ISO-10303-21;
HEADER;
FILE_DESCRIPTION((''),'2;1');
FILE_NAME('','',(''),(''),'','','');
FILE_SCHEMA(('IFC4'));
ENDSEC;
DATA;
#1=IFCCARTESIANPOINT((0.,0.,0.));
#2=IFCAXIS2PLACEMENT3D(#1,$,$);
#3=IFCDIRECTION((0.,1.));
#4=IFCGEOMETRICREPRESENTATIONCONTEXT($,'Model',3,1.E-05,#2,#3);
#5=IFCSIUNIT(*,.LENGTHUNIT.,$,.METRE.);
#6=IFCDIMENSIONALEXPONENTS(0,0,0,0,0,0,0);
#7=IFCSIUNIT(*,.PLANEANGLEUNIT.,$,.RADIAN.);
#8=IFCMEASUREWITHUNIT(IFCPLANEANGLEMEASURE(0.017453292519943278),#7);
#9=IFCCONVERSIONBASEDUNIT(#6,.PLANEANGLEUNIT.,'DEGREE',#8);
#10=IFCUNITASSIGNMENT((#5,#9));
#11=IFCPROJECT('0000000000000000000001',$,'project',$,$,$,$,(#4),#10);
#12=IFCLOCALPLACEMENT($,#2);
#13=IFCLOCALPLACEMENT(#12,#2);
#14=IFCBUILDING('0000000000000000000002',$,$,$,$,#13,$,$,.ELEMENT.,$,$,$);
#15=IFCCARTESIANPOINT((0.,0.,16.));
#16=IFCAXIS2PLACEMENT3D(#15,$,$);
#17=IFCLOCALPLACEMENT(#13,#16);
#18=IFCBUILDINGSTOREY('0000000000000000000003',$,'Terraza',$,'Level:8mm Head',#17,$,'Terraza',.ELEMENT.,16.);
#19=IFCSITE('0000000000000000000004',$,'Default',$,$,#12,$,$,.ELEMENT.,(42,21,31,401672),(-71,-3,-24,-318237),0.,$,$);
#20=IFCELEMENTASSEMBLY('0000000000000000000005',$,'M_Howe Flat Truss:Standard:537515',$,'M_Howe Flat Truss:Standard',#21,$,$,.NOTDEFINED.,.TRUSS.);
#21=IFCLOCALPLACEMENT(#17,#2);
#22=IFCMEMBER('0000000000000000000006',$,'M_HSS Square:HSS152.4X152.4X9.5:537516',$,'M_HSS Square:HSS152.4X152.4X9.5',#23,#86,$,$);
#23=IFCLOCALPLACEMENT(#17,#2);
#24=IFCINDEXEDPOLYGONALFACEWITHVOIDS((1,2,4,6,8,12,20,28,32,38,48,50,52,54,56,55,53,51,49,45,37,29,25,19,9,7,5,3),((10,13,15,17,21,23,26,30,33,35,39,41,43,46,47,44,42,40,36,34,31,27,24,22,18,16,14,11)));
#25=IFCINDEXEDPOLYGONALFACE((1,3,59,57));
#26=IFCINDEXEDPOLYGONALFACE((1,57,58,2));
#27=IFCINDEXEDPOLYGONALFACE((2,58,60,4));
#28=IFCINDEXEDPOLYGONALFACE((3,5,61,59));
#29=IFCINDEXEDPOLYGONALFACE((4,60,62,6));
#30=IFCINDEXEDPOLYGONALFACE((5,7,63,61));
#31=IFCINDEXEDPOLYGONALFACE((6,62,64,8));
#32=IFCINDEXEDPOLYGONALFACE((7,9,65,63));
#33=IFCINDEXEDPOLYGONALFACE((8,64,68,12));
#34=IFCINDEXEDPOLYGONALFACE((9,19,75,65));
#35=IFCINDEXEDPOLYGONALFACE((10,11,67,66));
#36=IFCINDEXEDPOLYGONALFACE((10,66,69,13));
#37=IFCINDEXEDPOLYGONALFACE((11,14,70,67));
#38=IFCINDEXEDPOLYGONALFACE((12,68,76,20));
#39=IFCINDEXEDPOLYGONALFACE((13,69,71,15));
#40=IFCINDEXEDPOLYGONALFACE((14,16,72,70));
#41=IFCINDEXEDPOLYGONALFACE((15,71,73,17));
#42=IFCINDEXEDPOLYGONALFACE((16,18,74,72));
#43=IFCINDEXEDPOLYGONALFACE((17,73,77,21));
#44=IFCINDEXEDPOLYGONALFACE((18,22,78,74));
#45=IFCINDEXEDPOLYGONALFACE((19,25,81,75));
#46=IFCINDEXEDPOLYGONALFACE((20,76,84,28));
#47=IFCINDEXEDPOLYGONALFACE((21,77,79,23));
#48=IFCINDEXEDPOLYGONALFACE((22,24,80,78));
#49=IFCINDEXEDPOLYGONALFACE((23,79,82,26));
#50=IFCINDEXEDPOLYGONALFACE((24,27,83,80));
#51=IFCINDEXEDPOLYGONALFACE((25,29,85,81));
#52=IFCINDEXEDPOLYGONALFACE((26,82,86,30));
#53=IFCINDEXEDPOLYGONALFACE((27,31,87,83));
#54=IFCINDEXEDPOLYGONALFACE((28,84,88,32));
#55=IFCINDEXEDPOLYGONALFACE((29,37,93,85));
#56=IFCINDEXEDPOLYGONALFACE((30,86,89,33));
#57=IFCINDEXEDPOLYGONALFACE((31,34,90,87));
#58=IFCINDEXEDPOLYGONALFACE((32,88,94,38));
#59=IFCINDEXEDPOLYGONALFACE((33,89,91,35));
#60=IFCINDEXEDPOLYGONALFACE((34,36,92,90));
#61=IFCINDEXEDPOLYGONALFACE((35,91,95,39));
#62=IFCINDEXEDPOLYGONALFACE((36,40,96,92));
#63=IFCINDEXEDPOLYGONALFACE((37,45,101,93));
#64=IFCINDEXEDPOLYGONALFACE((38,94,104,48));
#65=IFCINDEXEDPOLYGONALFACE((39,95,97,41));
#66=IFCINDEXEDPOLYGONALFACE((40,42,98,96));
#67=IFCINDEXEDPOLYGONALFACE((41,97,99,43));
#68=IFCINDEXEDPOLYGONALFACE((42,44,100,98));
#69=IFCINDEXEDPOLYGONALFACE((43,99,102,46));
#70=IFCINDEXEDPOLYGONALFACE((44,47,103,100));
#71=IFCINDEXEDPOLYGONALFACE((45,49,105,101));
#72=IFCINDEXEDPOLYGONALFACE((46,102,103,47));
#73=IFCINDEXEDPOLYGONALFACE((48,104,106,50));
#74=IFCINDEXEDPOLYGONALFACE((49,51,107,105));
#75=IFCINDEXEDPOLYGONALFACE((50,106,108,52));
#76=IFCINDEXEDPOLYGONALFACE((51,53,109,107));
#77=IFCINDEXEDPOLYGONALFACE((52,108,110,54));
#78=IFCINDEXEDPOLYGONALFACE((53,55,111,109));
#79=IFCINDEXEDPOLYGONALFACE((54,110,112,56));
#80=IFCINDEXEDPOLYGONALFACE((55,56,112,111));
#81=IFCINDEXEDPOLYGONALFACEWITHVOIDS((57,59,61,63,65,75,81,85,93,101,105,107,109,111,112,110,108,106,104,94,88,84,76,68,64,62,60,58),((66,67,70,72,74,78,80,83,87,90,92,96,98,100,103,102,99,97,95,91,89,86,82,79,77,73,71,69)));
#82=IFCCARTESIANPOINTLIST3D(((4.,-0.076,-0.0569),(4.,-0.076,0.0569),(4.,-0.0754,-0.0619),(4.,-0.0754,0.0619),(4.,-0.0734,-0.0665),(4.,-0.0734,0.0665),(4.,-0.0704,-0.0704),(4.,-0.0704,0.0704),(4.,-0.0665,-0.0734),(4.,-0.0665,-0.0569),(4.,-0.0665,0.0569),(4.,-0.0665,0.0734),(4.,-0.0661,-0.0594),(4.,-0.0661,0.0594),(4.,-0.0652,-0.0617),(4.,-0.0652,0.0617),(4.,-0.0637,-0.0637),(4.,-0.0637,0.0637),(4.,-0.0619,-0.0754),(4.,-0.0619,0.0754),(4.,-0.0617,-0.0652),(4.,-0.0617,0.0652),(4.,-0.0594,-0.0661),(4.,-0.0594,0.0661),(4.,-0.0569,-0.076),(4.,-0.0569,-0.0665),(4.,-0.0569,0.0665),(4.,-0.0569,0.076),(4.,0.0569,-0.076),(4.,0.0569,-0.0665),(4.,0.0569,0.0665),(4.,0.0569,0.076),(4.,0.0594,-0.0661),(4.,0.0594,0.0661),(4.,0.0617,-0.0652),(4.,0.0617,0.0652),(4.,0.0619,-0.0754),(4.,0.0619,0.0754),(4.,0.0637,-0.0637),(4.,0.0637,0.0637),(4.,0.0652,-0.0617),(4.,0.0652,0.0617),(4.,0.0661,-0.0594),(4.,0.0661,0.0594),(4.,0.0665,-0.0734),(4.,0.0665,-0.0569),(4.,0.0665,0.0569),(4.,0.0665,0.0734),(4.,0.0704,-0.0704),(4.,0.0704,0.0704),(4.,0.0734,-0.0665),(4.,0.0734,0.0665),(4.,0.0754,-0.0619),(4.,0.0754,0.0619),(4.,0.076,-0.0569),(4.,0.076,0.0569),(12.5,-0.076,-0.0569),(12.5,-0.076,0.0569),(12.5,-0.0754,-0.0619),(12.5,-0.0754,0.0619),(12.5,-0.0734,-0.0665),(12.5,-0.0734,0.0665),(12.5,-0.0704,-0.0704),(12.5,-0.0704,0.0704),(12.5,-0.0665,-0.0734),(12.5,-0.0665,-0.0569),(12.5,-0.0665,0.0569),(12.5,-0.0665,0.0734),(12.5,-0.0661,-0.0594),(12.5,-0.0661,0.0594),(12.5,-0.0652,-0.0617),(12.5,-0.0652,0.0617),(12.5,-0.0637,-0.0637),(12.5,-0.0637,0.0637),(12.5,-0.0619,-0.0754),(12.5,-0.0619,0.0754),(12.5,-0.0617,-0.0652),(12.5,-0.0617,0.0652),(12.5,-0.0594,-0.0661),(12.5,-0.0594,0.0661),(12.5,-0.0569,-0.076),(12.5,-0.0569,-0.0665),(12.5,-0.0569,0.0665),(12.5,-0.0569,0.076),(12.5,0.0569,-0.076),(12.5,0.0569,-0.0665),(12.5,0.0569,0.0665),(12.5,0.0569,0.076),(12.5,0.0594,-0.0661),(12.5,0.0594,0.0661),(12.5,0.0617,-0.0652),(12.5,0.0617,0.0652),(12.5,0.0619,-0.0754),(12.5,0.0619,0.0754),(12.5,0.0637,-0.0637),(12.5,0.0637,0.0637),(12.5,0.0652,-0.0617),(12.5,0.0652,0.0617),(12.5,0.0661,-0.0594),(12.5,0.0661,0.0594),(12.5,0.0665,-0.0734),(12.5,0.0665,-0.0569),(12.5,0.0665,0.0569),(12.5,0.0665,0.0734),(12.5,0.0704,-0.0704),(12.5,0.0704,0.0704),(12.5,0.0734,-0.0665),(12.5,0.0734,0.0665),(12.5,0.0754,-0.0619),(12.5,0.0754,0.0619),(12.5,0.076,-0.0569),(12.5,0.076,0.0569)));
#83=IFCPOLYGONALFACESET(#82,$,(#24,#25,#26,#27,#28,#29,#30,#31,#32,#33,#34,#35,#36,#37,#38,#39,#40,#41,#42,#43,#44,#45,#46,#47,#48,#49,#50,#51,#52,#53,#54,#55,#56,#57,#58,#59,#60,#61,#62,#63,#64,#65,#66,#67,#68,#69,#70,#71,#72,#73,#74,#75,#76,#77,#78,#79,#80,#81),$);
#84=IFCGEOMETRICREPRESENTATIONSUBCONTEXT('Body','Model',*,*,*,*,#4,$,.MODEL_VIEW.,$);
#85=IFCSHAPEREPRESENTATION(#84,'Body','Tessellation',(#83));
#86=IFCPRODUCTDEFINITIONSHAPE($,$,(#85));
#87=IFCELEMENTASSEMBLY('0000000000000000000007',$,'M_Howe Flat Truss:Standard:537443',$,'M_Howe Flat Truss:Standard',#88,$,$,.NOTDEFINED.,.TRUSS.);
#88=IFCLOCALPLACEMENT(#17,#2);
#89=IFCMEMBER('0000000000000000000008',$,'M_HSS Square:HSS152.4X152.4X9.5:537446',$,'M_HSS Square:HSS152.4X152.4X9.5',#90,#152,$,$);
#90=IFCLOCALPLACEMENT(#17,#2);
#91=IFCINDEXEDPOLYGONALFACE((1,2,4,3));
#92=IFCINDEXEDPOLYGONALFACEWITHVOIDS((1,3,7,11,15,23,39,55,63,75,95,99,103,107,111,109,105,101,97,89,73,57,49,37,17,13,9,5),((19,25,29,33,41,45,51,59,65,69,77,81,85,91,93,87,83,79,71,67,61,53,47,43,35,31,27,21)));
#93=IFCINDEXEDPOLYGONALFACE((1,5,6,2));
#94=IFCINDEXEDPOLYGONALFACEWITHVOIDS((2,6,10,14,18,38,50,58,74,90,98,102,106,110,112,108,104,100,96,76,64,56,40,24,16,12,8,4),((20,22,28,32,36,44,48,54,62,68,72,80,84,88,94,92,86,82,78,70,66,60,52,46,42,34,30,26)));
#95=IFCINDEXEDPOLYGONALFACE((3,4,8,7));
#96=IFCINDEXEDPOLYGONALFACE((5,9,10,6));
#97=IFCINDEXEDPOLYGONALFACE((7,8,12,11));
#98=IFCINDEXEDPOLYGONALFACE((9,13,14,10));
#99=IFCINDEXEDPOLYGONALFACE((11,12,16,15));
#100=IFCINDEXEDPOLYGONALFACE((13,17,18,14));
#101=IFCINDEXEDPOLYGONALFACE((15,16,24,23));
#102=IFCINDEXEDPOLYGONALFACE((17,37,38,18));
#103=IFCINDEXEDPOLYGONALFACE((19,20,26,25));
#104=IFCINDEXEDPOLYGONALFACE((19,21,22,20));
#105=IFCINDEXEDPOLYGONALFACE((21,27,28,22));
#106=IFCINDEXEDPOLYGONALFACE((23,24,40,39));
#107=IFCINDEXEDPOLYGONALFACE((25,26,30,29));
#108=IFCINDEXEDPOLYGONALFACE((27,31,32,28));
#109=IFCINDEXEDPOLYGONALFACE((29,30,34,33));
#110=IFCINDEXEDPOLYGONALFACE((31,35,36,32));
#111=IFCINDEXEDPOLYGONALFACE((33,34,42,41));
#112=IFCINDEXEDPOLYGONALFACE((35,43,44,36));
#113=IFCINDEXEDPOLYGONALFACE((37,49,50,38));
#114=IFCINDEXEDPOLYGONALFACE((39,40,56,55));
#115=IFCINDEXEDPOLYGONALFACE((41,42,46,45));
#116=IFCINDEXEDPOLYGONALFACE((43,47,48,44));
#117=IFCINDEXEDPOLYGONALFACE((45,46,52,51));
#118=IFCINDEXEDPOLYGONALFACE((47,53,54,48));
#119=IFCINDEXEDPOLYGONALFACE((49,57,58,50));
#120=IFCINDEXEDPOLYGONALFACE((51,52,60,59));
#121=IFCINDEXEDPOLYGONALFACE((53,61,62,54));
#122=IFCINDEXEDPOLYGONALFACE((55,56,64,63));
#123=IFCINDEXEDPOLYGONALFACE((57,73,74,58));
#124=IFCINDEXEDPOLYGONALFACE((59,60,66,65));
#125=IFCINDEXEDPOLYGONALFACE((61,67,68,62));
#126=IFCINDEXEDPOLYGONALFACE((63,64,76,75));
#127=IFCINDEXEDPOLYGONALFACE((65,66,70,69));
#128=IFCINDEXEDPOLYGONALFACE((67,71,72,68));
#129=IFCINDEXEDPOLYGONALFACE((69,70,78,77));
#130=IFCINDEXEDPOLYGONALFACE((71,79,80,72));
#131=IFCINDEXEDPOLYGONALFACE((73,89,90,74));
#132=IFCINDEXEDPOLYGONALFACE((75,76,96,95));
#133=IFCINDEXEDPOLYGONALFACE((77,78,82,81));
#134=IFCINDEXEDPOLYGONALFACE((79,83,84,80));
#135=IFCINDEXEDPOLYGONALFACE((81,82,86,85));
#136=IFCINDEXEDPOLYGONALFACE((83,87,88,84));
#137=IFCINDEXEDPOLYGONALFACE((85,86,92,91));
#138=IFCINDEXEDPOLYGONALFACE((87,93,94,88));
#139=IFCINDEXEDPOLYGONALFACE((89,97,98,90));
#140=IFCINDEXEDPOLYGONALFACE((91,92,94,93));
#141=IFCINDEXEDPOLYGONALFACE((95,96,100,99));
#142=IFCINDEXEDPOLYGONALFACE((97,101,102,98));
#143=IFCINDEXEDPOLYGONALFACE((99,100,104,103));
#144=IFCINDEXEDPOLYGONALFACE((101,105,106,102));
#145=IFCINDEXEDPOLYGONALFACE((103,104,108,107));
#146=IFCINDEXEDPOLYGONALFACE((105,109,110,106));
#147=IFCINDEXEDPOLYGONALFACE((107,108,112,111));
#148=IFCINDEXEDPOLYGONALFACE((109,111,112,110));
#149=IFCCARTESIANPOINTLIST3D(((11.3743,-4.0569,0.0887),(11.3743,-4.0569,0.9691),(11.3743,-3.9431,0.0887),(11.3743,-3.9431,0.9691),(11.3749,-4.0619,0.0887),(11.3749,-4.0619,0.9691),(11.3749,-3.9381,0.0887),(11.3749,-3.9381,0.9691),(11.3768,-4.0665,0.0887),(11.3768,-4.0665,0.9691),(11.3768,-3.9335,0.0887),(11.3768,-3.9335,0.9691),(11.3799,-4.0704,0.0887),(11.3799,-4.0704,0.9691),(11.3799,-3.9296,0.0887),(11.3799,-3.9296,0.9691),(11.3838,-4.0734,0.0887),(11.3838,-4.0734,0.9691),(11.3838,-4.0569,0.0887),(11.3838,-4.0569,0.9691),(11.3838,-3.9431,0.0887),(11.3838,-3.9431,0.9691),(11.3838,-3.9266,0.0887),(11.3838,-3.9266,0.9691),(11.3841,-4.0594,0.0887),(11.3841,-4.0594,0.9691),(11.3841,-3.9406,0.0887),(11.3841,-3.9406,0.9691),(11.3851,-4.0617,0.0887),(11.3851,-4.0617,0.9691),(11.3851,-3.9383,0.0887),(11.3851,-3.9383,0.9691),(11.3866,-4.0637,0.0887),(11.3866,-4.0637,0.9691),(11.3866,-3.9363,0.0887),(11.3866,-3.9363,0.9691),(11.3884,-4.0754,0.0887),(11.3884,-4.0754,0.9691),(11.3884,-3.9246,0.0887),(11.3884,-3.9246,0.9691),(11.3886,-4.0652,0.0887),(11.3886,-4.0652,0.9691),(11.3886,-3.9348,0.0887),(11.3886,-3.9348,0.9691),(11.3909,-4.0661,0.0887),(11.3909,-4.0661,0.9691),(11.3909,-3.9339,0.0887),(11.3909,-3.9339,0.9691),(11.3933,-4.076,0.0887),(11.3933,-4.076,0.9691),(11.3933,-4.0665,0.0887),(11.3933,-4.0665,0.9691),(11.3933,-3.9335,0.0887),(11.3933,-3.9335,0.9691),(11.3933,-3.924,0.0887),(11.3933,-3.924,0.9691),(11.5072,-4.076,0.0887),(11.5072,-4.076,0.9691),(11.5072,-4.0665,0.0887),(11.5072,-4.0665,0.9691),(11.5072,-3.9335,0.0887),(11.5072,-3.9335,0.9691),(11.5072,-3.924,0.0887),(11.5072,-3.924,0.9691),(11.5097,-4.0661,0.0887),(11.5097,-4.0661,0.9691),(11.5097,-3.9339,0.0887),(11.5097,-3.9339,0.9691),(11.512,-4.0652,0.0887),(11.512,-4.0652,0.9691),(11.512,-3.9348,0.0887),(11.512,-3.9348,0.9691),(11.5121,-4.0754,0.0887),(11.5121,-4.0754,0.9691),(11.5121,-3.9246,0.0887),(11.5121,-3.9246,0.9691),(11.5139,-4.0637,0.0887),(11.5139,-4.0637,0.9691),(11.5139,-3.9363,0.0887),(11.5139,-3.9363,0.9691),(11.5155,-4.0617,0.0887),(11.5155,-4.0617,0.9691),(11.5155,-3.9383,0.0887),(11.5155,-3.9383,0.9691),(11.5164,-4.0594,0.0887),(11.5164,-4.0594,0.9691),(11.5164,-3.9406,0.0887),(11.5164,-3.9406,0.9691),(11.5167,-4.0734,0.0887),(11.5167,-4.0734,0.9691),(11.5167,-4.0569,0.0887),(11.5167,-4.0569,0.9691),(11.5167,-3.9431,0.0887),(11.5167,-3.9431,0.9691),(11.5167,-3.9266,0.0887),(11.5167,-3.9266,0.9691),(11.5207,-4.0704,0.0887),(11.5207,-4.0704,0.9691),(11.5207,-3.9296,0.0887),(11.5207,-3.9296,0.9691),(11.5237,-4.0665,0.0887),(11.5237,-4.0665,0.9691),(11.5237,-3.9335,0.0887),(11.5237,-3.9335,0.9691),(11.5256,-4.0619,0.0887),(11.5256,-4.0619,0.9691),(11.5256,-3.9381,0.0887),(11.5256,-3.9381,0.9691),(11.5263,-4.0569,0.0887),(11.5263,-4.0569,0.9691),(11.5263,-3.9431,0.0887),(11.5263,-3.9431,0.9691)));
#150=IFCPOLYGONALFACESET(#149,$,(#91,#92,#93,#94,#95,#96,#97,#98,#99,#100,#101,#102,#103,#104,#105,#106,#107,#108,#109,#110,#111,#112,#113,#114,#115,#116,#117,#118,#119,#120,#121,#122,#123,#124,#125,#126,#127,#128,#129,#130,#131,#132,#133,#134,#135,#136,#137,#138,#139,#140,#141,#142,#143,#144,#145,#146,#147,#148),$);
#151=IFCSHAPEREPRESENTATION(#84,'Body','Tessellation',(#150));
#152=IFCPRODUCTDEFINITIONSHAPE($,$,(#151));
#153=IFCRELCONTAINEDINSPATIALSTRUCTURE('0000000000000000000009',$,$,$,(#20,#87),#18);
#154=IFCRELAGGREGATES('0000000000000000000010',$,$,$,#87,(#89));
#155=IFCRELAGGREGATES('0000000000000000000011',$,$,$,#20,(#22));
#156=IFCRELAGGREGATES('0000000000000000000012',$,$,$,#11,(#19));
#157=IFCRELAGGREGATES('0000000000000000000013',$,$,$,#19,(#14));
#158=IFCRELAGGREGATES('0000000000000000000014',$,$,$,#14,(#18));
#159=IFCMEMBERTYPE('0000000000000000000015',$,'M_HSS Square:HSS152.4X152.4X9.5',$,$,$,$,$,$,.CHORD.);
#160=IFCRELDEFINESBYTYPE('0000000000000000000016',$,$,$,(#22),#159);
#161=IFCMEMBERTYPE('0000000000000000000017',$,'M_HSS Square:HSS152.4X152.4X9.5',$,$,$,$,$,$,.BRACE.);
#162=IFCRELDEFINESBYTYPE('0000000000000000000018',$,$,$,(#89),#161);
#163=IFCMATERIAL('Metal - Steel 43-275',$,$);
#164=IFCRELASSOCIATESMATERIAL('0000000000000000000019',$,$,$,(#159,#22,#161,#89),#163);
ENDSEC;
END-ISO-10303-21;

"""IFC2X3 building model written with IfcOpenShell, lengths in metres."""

from ifc_helpers import new_model, entity, si_unit, converted_unit, direction, frame, frame_2d, origin, place, context, subcontext, project, spatial, polyline, circle_curve, parameter, trimmed, segment, composite_curve, outline, extrude, source, transform, mapped, material, type_object, type_shapes, element, aggregate, save


model = new_model("IFC2X3")

# Units and contexts
model_context = context("Model", 3, precision=1e-05, world=origin(), true_north=direction((0.0, 1.0)))
body_context = subcontext(model_context, "Body", "Model", "MODEL_VIEW")
ifc_project = project(units=[si_unit("LENGTHUNIT", "METRE"), converted_unit("PLANEANGLEUNIT", "DEGREE", entity("IfcPlaneAngleMeasure", 0.017453292519943278), si_unit("PLANEANGLEUNIT", "RADIAN"), dimensions=[0, 0, 0, 0, 0, 0, 0])], contexts=[model_context])

# Site, building, storey
site_placement = place(None, origin())
site = spatial("IfcSite", under=ifc_project, at=site_placement, Name="Default", CompositionType="ELEMENT", RefLatitude=(42, 21, 31, 401672), RefLongitude=(-71, -3, -24, -318237), RefElevation=0.0)
building_placement = place(site_placement, origin())
building = spatial("IfcBuilding", under=site, at=building_placement, CompositionType="ELEMENT")
storey_placement = place(building_placement, frame((0.0, 0.0, 16.0)))
storey = spatial("IfcBuildingStorey", under=building, at=storey_placement, Name="Terraza", ObjectType="Level:8mm Head", LongName="Terraza", CompositionType="ELEMENT", Elevation=16.0)

# Element assemblies, members
assembly_1_placement = place(storey_placement, origin())
assembly_1 = element("IfcElementAssembly", 1, at=assembly_1_placement, inside=storey, Name="M_Howe Flat Truss:Standard:537515", ObjectType="M_Howe Flat Truss:Standard", AssemblyPlace="NOTDEFINED", PredefinedType="TRUSS")
ifc_material_1 = material(Name="Metal - Steel 43-275")
member_type_1 = type_object("IfcMemberType", Name="M_HSS Square:HSS152.4X152.4X9.5", PredefinedType="CHORD", material=ifc_material_1)
shared_shape_1 = source(origin(), body_context, "Body", "SweptSolid", [
    extrude(outline(composite_curve([segment(polyline([(-0.0569, -0.076), (0.0569, -0.076)]), True, "CONTINUOUS"), segment(trimmed(circle_curve(frame_2d((0.0569, -0.0569), x_axis=(0.0, 1.0)), 0.0191), [parameter(180.0)], [parameter(270.0)], True, "PARAMETER"), True, "CONTINUOUS"), segment(polyline([(0.076, -0.0569), (0.076, 0.0569)]), True, "CONTINUOUS"), segment(trimmed(circle_curve(frame_2d((0.0569, 0.0569), x_axis=(0.0, 1.0)), 0.0191), [parameter(270.0)], [parameter(0.0)], True, "PARAMETER"), True, "CONTINUOUS"), segment(polyline([(0.0569, 0.076), (-0.0569, 0.076)]), True, "CONTINUOUS"), segment(trimmed(circle_curve(frame_2d((-0.0569, 0.0569), x_axis=(0.0, 1.0)), 0.0191), [parameter(0.0)], [parameter(90.0)], True, "PARAMETER"), True, "CONTINUOUS"), segment(polyline([(-0.076, 0.0569), (-0.076, -0.0569)]), True, "CONTINUOUS"), segment(trimmed(circle_curve(frame_2d((-0.0569, -0.0569), x_axis=(0.0, 1.0)), 0.0191), [parameter(90.0)], [parameter(180.0)], True, "PARAMETER"), True, "CONTINUOUS")], self_intersect=False), holes=[composite_curve([segment(trimmed(circle_curve(frame_2d((-0.0569, 0.0569), x_axis=(0.0, 1.0)), 0.0095), [parameter(360.0)], [parameter(90.0)], True, "PARAMETER"), False, "CONTINUOUS"), segment(polyline([(-0.0569, 0.0665), (0.0569, 0.0665)]), True, "CONTINUOUS"), segment(trimmed(circle_curve(frame_2d((0.0569, 0.0569), x_axis=(0.0, 1.0)), 0.0095), [parameter(270.0)], [parameter(360.0)], True, "PARAMETER"), False, "CONTINUOUS"), segment(polyline([(0.0665, 0.0569), (0.0665, -0.0569)]), True, "CONTINUOUS"), segment(trimmed(circle_curve(frame_2d((0.0569, -0.0569), x_axis=(0.0, 1.0)), 0.0095), [parameter(180.0)], [parameter(270.0)], True, "PARAMETER"), False, "CONTINUOUS"), segment(polyline([(0.0569, -0.0665), (-0.0569, -0.0665)]), True, "CONTINUOUS"), segment(trimmed(circle_curve(frame_2d((-0.0569, -0.0569), x_axis=(0.0, 1.0)), 0.0095), [parameter(90.0)], [parameter(180.0)], True, "PARAMETER"), False, "CONTINUOUS"), segment(polyline([(-0.0665, -0.0569), (-0.0665, 0.0569)]), True, "CONTINUOUS")], self_intersect=False)]), frame((-4.25, 0.0, 0.0), z_axis=(1.0, 0.0, 0.0), x_axis=(0.0, 0.0, -1.0)), (0.0, 0.0, 1.0), 8.5),
])
type_shapes(member_type_1, [shared_shape_1])
member_1_placement = place(assembly_1_placement, frame((8.25, 0.0, 0.0)))
member_1 = element("IfcMember", 2, at=member_1_placement, type_object=member_type_1, material=ifc_material_1, Name="M_HSS Square:HSS152.4X152.4X9.5:537516", ObjectType="M_HSS Square:HSS152.4X152.4X9.5", context=body_context, shape_type="MappedRepresentation", body=[
    mapped(shared_shape_1, transform((0.0, 0.0, 0.0), scale=1.0)),
])
assembly_2_placement = place(storey_placement, origin())
assembly_2 = element("IfcElementAssembly", 3, at=assembly_2_placement, inside=storey, Name="M_Howe Flat Truss:Standard:537443", ObjectType="M_Howe Flat Truss:Standard", AssemblyPlace="NOTDEFINED", PredefinedType="TRUSS")
member_type_2 = type_object("IfcMemberType", Name="M_HSS Square:HSS152.4X152.4X9.5", PredefinedType="BRACE", material=ifc_material_1)
shared_shape_2 = source(origin(), body_context, "Body", "SweptSolid", [
    extrude(outline(composite_curve([segment(polyline([(-0.0569, -0.076), (0.0569, -0.076)]), True, "CONTINUOUS"), segment(trimmed(circle_curve(frame_2d((0.0569, -0.0569), x_axis=(0.0, 1.0)), 0.0191), [parameter(180.0)], [parameter(270.0)], True, "PARAMETER"), True, "CONTINUOUS"), segment(polyline([(0.076, -0.0569), (0.076, 0.0569)]), True, "CONTINUOUS"), segment(trimmed(circle_curve(frame_2d((0.0569, 0.0569), x_axis=(0.0, 1.0)), 0.0191), [parameter(270.0)], [parameter(0.0)], True, "PARAMETER"), True, "CONTINUOUS"), segment(polyline([(0.0569, 0.076), (-0.0569, 0.076)]), True, "CONTINUOUS"), segment(trimmed(circle_curve(frame_2d((-0.0569, 0.0569), x_axis=(0.0, 1.0)), 0.0191), [parameter(0.0)], [parameter(90.0)], True, "PARAMETER"), True, "CONTINUOUS"), segment(polyline([(-0.076, 0.0569), (-0.076, -0.0569)]), True, "CONTINUOUS"), segment(trimmed(circle_curve(frame_2d((-0.0569, -0.0569), x_axis=(0.0, 1.0)), 0.0191), [parameter(90.0)], [parameter(180.0)], True, "PARAMETER"), True, "CONTINUOUS")], self_intersect=False), holes=[composite_curve([segment(trimmed(circle_curve(frame_2d((-0.0569, 0.0569), x_axis=(0.0, 1.0)), 0.0095), [parameter(360.0)], [parameter(90.0)], True, "PARAMETER"), False, "CONTINUOUS"), segment(polyline([(-0.0569, 0.0665), (0.0569, 0.0665)]), True, "CONTINUOUS"), segment(trimmed(circle_curve(frame_2d((0.0569, 0.0569), x_axis=(0.0, 1.0)), 0.0095), [parameter(270.0)], [parameter(360.0)], True, "PARAMETER"), False, "CONTINUOUS"), segment(polyline([(0.0665, 0.0569), (0.0665, -0.0569)]), True, "CONTINUOUS"), segment(trimmed(circle_curve(frame_2d((0.0569, -0.0569), x_axis=(0.0, 1.0)), 0.0095), [parameter(180.0)], [parameter(270.0)], True, "PARAMETER"), False, "CONTINUOUS"), segment(polyline([(0.0569, -0.0665), (-0.0569, -0.0665)]), True, "CONTINUOUS"), segment(trimmed(circle_curve(frame_2d((-0.0569, -0.0569), x_axis=(0.0, 1.0)), 0.0095), [parameter(90.0)], [parameter(180.0)], True, "PARAMETER"), False, "CONTINUOUS"), segment(polyline([(-0.0665, -0.0569), (-0.0665, 0.0569)]), True, "CONTINUOUS")], self_intersect=False)]), frame((-0.4426, 0.0, 0.0), z_axis=(1.0, 0.0, 0.0), x_axis=(0.0, 0.0, -1.0)), (0.0, 0.0, 1.0), 0.8804),
])
type_shapes(member_type_2, [shared_shape_2])
member_2_placement = place(assembly_2_placement, frame((11.4503, -4.0, 0.5312), z_axis=(1.0, 0.0, 0.0), x_axis=(0.0, 0.0, 1.0)))
member_2 = element("IfcMember", 4, at=member_2_placement, type_object=member_type_2, material=ifc_material_1, Name="M_HSS Square:HSS152.4X152.4X9.5:537446", ObjectType="M_HSS Square:HSS152.4X152.4X9.5", context=body_context, shape_type="MappedRepresentation", body=[
    mapped(shared_shape_2, transform((0.0, 0.0, 0.0), scale=1.0)),
])

aggregate(assembly_2, [member_2])
aggregate(assembly_1, [member_1])

save(model, "model.ifc")
